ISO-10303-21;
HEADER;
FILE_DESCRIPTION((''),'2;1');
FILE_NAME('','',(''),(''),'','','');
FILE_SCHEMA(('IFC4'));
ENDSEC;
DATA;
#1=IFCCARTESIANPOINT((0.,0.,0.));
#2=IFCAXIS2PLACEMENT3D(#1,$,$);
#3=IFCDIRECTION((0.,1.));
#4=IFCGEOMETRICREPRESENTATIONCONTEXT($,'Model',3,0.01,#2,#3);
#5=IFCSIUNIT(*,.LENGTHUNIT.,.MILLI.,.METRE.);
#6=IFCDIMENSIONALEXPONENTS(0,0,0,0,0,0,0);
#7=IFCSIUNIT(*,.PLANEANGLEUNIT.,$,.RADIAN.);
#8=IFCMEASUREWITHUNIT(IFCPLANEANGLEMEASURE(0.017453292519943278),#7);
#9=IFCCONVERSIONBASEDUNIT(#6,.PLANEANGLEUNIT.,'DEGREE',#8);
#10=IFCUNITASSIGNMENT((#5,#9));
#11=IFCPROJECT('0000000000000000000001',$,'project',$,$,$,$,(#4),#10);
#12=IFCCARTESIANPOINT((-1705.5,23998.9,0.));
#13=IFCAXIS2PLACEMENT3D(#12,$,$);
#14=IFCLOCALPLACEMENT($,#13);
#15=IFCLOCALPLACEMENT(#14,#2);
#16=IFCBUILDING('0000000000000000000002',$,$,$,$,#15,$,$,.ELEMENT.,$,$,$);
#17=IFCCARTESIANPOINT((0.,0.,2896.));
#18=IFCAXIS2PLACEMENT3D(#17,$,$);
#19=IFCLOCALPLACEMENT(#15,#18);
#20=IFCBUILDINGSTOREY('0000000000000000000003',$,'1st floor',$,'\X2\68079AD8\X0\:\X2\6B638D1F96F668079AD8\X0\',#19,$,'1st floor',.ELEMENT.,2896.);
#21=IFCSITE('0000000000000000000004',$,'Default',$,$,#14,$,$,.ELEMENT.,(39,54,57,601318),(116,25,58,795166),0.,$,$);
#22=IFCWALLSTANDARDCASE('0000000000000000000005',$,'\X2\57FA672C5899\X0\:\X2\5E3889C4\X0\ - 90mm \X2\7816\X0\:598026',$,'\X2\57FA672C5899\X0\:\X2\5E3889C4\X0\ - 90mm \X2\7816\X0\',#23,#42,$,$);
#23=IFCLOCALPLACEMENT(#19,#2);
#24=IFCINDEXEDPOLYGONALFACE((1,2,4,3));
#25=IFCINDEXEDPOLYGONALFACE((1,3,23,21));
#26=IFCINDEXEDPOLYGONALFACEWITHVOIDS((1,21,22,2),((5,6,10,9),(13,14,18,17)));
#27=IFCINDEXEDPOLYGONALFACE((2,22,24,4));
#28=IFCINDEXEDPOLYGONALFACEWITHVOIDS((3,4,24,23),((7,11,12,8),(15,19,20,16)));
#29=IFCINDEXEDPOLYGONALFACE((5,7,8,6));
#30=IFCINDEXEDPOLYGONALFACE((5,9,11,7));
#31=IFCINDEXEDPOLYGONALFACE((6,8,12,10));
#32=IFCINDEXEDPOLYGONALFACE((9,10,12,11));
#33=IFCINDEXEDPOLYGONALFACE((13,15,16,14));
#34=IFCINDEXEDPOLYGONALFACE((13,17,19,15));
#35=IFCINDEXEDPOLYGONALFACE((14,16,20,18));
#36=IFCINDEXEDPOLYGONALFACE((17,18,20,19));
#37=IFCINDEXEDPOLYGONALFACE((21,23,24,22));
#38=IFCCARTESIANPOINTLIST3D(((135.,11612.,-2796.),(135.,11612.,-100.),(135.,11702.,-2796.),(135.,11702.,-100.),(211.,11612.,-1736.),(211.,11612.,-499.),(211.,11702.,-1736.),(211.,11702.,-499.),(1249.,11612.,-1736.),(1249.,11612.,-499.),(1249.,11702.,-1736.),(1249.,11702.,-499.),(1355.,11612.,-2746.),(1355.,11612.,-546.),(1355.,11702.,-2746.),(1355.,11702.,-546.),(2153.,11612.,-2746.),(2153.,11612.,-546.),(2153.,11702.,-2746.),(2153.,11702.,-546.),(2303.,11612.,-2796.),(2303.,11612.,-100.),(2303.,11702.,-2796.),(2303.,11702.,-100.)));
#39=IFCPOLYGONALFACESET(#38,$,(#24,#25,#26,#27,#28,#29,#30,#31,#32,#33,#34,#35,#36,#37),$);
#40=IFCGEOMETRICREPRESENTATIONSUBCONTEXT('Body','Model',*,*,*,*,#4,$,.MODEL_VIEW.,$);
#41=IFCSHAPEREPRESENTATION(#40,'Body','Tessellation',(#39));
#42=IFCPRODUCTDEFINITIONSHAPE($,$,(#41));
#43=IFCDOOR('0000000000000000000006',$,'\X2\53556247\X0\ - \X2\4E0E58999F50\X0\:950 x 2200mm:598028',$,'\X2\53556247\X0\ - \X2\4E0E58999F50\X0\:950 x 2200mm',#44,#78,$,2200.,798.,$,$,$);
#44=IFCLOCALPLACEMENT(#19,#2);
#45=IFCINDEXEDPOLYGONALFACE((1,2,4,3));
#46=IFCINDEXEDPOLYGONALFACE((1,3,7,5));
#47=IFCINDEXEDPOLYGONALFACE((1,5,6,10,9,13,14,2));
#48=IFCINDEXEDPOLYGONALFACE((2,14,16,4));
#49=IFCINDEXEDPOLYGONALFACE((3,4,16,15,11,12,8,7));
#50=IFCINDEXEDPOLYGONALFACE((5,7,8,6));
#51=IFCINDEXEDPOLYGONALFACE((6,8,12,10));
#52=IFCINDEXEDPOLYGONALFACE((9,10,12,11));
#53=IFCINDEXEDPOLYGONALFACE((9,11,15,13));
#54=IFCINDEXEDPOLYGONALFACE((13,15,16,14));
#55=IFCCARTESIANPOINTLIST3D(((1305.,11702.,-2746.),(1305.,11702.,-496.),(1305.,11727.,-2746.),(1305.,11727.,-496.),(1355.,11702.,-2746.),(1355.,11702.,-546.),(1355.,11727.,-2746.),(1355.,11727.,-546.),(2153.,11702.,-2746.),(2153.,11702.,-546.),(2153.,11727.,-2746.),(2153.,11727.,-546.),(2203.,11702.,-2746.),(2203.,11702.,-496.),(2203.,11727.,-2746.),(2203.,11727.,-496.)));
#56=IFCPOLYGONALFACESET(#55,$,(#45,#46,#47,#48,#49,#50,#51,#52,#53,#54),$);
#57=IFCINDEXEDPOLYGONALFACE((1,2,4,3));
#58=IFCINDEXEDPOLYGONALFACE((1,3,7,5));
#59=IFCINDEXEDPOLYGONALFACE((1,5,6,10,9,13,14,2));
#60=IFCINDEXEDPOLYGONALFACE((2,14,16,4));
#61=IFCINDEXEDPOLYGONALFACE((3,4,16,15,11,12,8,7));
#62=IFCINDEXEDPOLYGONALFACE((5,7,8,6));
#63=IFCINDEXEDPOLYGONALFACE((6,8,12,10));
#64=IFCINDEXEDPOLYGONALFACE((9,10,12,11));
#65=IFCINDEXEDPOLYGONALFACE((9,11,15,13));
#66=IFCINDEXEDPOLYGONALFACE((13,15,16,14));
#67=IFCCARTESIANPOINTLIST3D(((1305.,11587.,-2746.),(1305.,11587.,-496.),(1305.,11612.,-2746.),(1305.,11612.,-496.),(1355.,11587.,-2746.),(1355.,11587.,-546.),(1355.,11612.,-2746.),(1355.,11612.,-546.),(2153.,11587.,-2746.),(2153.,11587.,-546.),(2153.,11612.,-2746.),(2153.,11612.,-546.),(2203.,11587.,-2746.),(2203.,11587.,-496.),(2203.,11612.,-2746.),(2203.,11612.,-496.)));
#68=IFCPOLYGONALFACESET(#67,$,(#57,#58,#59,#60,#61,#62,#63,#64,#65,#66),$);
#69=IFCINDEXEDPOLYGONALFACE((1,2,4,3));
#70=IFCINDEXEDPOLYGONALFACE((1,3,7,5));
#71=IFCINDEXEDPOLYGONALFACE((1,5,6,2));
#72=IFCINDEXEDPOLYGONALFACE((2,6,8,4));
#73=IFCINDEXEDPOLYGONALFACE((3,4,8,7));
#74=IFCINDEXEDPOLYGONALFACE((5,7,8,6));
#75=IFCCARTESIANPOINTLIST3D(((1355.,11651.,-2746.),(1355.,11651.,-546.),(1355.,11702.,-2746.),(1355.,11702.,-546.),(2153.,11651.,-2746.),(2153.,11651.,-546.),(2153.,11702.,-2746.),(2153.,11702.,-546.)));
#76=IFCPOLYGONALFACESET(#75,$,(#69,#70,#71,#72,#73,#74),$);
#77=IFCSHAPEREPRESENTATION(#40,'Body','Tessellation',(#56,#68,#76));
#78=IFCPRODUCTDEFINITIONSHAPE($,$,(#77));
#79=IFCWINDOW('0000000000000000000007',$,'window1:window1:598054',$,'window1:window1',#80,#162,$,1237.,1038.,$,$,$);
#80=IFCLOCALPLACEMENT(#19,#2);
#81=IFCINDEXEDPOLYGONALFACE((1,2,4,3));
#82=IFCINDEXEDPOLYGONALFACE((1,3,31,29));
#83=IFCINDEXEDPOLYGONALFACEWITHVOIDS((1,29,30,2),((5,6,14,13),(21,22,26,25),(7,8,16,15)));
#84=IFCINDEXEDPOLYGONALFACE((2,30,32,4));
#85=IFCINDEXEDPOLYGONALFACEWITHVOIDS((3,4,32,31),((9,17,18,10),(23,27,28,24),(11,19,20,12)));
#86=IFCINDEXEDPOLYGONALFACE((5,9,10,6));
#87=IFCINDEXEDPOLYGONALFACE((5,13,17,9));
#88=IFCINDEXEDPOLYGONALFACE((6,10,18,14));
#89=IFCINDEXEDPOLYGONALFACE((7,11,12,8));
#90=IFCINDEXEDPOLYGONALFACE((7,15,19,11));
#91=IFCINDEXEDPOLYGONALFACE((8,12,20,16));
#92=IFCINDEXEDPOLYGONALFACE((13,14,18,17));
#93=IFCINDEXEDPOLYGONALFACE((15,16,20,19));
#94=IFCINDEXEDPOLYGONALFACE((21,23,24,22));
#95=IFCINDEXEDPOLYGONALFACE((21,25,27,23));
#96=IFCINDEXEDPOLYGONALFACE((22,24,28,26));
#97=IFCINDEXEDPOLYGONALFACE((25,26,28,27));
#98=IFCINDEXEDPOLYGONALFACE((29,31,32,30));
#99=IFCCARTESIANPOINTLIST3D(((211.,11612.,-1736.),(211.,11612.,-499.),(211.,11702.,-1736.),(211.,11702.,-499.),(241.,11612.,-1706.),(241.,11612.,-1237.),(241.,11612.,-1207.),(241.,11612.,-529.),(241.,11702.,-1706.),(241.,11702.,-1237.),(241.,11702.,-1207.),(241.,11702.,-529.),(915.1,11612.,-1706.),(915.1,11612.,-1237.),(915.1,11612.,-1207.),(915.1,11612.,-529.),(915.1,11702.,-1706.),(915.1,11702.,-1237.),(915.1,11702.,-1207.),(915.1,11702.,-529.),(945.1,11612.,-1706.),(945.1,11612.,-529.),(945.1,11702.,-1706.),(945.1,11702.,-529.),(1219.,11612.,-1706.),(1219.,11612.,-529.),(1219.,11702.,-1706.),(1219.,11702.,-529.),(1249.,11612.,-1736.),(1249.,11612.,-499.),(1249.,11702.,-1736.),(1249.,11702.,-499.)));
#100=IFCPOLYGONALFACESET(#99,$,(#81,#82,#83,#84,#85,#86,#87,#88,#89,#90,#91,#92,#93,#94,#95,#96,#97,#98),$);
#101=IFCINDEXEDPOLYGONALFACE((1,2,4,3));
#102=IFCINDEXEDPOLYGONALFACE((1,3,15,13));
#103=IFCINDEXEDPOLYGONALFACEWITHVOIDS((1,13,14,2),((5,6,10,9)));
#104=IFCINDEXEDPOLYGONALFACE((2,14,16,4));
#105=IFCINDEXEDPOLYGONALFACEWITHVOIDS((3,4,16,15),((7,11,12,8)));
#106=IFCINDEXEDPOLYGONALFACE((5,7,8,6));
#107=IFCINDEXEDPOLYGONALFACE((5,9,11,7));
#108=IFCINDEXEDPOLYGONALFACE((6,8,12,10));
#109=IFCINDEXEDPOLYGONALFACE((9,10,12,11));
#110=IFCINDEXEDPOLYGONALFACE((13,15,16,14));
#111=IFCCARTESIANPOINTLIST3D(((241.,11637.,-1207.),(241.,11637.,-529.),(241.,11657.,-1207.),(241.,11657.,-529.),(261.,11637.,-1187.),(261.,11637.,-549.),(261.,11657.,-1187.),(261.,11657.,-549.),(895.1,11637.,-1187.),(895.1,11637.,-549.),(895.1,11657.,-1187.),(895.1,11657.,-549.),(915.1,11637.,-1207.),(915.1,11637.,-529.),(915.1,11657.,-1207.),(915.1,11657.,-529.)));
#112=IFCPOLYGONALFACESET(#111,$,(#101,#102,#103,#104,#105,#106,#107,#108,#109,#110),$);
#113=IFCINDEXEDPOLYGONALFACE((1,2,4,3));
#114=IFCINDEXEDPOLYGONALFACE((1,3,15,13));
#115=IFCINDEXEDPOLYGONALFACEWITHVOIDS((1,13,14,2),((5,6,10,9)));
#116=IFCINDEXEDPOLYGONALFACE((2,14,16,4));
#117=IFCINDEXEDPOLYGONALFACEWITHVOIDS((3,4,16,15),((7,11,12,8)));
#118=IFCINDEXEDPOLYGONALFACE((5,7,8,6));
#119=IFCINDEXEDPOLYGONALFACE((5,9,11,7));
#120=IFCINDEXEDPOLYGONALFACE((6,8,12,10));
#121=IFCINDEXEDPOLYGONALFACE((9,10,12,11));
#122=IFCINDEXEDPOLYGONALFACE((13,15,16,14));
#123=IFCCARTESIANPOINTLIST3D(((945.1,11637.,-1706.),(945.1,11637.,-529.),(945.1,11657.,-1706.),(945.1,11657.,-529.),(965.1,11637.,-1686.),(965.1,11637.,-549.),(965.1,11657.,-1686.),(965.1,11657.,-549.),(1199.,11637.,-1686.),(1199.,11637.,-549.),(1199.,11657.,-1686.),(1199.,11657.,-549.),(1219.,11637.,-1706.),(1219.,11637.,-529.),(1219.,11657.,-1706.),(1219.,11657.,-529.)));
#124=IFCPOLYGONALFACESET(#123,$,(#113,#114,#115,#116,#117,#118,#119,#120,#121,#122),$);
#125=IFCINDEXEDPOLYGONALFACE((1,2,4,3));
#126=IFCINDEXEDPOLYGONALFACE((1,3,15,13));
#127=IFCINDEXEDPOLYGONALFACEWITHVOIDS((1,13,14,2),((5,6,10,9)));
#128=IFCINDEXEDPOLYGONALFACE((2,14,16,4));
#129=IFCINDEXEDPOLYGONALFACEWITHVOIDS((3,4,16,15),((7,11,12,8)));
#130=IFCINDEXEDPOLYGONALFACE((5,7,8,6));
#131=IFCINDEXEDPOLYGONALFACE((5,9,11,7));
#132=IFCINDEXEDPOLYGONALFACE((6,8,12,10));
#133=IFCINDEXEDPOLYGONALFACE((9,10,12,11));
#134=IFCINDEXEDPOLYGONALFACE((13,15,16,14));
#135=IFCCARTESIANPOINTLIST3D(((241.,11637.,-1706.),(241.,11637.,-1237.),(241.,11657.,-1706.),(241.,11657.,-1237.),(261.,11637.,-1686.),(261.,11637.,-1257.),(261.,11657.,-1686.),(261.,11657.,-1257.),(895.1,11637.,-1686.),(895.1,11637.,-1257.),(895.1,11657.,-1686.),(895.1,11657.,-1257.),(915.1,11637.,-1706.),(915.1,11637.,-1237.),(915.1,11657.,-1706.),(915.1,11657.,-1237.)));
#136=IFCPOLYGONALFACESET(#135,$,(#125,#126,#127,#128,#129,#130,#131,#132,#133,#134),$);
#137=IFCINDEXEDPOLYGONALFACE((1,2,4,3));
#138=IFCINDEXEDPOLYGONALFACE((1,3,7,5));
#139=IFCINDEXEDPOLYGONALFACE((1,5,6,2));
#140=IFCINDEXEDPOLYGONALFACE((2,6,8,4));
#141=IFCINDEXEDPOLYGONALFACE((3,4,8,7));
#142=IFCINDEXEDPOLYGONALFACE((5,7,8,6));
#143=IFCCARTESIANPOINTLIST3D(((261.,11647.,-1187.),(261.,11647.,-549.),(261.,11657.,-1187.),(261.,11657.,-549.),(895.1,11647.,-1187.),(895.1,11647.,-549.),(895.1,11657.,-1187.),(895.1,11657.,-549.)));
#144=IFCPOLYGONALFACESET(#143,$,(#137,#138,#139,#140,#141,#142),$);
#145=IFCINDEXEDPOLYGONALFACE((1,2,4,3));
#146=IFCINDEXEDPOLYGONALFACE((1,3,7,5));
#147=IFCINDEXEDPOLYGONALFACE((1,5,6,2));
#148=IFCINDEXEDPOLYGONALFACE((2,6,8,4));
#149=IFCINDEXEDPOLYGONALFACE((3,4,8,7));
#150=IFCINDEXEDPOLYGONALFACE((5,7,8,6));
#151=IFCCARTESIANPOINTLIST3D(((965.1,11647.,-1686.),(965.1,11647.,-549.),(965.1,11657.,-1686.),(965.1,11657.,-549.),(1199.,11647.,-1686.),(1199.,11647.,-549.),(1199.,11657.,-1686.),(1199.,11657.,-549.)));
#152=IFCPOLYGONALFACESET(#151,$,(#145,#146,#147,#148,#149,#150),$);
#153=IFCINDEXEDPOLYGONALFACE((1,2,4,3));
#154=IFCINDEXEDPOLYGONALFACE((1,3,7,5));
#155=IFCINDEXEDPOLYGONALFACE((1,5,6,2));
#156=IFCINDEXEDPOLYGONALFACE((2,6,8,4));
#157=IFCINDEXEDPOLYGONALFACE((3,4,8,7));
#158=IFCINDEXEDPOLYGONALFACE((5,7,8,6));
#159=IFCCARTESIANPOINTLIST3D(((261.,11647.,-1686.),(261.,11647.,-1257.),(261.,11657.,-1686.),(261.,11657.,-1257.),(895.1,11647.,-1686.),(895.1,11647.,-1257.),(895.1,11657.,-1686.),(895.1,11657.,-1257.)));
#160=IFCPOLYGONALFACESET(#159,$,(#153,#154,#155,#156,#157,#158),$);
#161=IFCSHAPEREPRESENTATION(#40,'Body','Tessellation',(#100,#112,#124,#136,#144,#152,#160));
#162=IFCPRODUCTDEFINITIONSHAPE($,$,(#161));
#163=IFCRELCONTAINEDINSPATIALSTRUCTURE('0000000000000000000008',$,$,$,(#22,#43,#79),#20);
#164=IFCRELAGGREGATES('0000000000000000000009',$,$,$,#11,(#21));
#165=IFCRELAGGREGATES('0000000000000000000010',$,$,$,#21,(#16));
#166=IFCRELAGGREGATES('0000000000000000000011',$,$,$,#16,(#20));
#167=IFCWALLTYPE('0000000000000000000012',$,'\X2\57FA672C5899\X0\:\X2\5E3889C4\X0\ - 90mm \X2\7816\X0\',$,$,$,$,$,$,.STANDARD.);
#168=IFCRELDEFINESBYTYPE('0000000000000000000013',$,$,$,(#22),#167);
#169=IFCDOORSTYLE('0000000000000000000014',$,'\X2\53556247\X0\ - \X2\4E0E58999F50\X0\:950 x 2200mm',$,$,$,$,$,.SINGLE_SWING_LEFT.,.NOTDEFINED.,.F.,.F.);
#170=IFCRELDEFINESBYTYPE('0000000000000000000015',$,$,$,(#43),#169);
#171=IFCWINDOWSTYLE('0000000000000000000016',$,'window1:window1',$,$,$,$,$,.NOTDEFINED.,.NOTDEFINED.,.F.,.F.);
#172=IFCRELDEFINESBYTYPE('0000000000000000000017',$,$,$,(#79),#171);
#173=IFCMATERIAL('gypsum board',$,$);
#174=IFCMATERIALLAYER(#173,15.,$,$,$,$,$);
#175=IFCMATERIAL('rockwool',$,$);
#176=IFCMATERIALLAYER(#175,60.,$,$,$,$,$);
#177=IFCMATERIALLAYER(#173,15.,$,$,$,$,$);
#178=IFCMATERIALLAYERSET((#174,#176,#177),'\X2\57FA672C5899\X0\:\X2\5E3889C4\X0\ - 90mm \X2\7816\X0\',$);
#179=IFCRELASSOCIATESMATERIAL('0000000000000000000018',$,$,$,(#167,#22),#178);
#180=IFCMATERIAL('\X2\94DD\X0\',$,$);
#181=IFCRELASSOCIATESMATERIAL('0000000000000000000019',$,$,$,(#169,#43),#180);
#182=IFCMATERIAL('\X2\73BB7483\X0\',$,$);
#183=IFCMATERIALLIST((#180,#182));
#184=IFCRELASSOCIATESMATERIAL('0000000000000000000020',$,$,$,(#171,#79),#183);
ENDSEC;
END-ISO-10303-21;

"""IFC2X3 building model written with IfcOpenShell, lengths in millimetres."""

from ifc_helpers import new_model, entity, si_unit, converted_unit, direction, frame, frame_2d, origin, origin_2d_with_axis, place, context, subcontext, project, spatial, polyline, rectangle, outline, extrude, source, transform, mapped, material, material_list, layer, layer_set, layer_usage, type_object, type_shapes, element, fill, save


model = new_model("IFC2X3")

# Units and contexts
model_context = context("Model", 3, precision=0.01, world=origin(), true_north=direction((0.0, 1.0)))
body_context = subcontext(model_context, "Body", "Model", "MODEL_VIEW")
ifc_project = project(units=[si_unit("LENGTHUNIT", "METRE", prefix="MILLI"), converted_unit("PLANEANGLEUNIT", "DEGREE", entity("IfcPlaneAngleMeasure", 0.017453292519943278), si_unit("PLANEANGLEUNIT", "RADIAN"), dimensions=[0, 0, 0, 0, 0, 0, 0])], contexts=[model_context])

# Site, building, storey
site_placement = place(None, frame((-1705.5, 23998.9, 0.0)))
site = spatial("IfcSite", under=ifc_project, at=site_placement, Name="Default", CompositionType="ELEMENT", RefLatitude=(39, 54, 57, 601318), RefLongitude=(116, 25, 58, 795166), RefElevation=0.0)
building_placement = place(site_placement, origin())
building = spatial("IfcBuilding", under=site, at=building_placement, CompositionType="ELEMENT")
storey_placement = place(building_placement, frame((0.0, 0.0, 2896.0)))
storey = spatial("IfcBuildingStorey", under=building, at=storey_placement, Name="1st floor", ObjectType="标高:正负零标高", LongName="1st floor", CompositionType="ELEMENT", Elevation=2896.0)

# Shared definitions
ifc_material_1 = material(Name="gypsum board")
ifc_layer_1 = layer(ifc_material_1, 15.0)
ifc_material_2 = material(Name="rockwool")
ifc_layer_2 = layer(ifc_material_2, 60.0)
ifc_layer_3 = layer(ifc_material_1, 15.0)
ifc_layer_set = layer_set([ifc_layer_1, ifc_layer_2, ifc_layer_3], Name="基本墙:常规 - 90mm 砖")
wall_type = type_object("IfcWallType", Name="基本墙:常规 - 90mm 砖", PredefinedType="STANDARD", material=ifc_layer_set)

# Wall, openings, door, window
ifc_layer_usage_1 = layer_usage(ifc_layer_set, "AXIS2", "NEGATIVE", 45.0)
wall_1_placement = place(storey_placement, frame((2303.0, 11657.0, -2796.0), z_axis=(0.0, 0.0, 1.0), x_axis=(-1.0, 0.0, 0.0)))
wall_1 = element("IfcWallStandardCase", 1, at=wall_1_placement, inside=storey, type_object=wall_type, material=ifc_layer_usage_1, Name="基本墙:常规 - 90mm 砖:598026", ObjectType="基本墙:常规 - 90mm 砖", context=body_context, shape_type="SweptSolid", body=[
    extrude(rectangle(XDim=2168.0, YDim=90.0, at=frame_2d((1084.0, 0.0), x_axis=(-1.0, 0.0))), origin(), (0.0, 0.0, 1.0), 2696.0),
])
opening_1_placement = place(wall_1_placement, frame((948.0, 45.0, 50.0)))
opening_1 = element("IfcOpeningElement", 2, at=opening_1_placement, cuts=wall_1, ObjectType="Opening", context=body_context, shape_type="SweptSolid", body=[
    extrude(rectangle(XDim=798.0, YDim=2200.0, at=frame_2d((1100.0, 399.0), x_axis=(0.0, -1.0))), frame((0.0, 0.0, 0.0), z_axis=(0.0, -1.0, 0.0), x_axis=(0.0, 0.0, 1.0)), (0.0, 0.0, 1.0), 90.0),
])
opening_2_placement = place(wall_1_placement, frame((2092.0, 45.0, 1060.0)))
opening_2 = element("IfcOpeningElement", 3, at=opening_2_placement, cuts=wall_1, ObjectType="Opening", context=body_context, shape_type="SweptSolid", body=[
    extrude(rectangle(XDim=1237.0, YDim=1038.0, at=frame_2d((618.5, 519.0), x_axis=(1.0, 0.0))), frame((0.0, 0.0, 0.0), z_axis=(0.0, -1.0, 0.0), x_axis=(0.0, 0.0, 1.0)), (0.0, 0.0, 1.0), 90.0),
])
ifc_material_3 = material(Name="铝")
door_style = type_object("IfcDoorStyle", Name="单扇 - 与墙齐:950 x 2200mm", ConstructionType="NOTDEFINED", OperationType="SINGLE_SWING_LEFT", ParameterTakesPrecedence=False, Sizeable=False, material=ifc_material_3)
shared_shape_1 = source(origin(), body_context, "Body", "SweptSolid", [
    extrude(outline(polyline([(-449.0, -1137.5), (449.0, -1137.5), (449.0, 1112.5), (399.0, 1112.5), (399.0, -1087.5), (-399.0, -1087.5), (-399.0, 1112.5), (-449.0, 1112.5), (-449.0, -1137.5)])), frame((399.0, 115.0, 1112.5), z_axis=(0.0, -1.0, 0.0), x_axis=(-1.0, 0.0, 0.0)), (0.0, 0.0, 1.0), 25.0),
    extrude(outline(polyline([(-1137.5, -449.0), (1112.5, -449.0), (1112.5, -399.0), (-1087.5, -399.0), (-1087.5, 399.0), (1112.5, 399.0), (1112.5, 449.0), (-1137.5, 449.0), (-1137.5, -449.0)])), frame((399.0, 0.0, 1112.5), z_axis=(0.0, -1.0, 0.0), x_axis=(0.0, 0.0, -1.0)), (0.0, 0.0, 1.0), 25.0),
    extrude(rectangle(XDim=798.0, YDim=51.0, at=origin_2d_with_axis()), frame((399.0, 64.5, 0.0)), (0.0, 0.0, 1.0), 2200.0),
])
type_shapes(door_style, [shared_shape_1])
door_placement = place(opening_1_placement, frame((0.0, 0.0, 0.0), z_axis=(0.0, 0.0, 1.0), x_axis=(-1.0, 0.0, 0.0)))
door = element("IfcDoor", 4, at=door_placement, inside=storey, type_object=door_style, material=ifc_material_3, Name="单扇 - 与墙齐:950 x 2200mm:598028", ObjectType="单扇 - 与墙齐:950 x 2200mm", OverallHeight=2200.0, OverallWidth=798.0, context=body_context, shape_type="MappedRepresentation", body=[
    mapped(shared_shape_1, transform((0.0, 0.0, 0.0), scale=1.0)),
])
fill(opening_1, door)
ifc_material_4 = material(Name="玻璃")
ifc_material_list = material_list([ifc_material_3, ifc_material_4])
window_style = type_object("IfcWindowStyle", Name="window1:window1", ConstructionType="NOTDEFINED", OperationType="NOTDEFINED", ParameterTakesPrecedence=False, Sizeable=False, material=ifc_material_list)
shared_shape_2 = source(origin(), body_context, "Body", "SweptSolid", [
    extrude(outline(polyline([(-618.5, -519.0), (618.5, -519.0), (618.5, 519.0), (-618.5, 519.0), (-618.5, -519.0)]), holes=[polyline([(-588.5, -215.1), (588.5, -215.1), (588.5, -489.0), (-588.5, -489.0), (-588.5, -215.1)]), polyline([(89.5, -185.1), (-588.5, -185.1), (-588.5, 489.0), (89.5, 489.0), (89.5, -185.1)]), polyline([(119.5, 489.0), (588.5, 489.0), (588.5, -185.1), (119.5, -185.1), (119.5, 489.0)])]), frame((519.0, 0.0, 618.5), z_axis=(0.0, 1.0, 0.0), x_axis=(0.0, 0.0, -1.0)), (0.0, 0.0, 1.0), 90.0),
    extrude(outline(polyline([(-337.0, -339.0), (337.0, -339.0), (337.0, 339.0), (-337.0, 339.0), (-337.0, -339.0)]), holes=[polyline([(-317.0, -319.0), (-317.0, 319.0), (317.0, 319.0), (317.0, -319.0), (-317.0, -319.0)])]), frame((367.0, 25.0, 868.0), z_axis=(0.0, 1.0, 0.0), x_axis=(1.0, 0.0, 0.0)), (0.0, 0.0, 1.0), 20.0),
    extrude(outline(polyline([(-137.0, -588.5), (137.0, -588.5), (137.0, 588.5), (-137.0, 588.5), (-137.0, -588.5)]), holes=[polyline([(-117.0, -568.5), (-117.0, 568.5), (117.0, 568.5), (117.0, -568.5), (-117.0, -568.5)])]), frame((871.0, 25.0, 618.5), z_axis=(0.0, 1.0, 0.0), x_axis=(1.0, 0.0, 0.0)), (0.0, 0.0, 1.0), 20.0),
    extrude(outline(polyline([(-337.0, -234.5), (337.0, -234.5), (337.0, 234.5), (-337.0, 234.5), (-337.0, -234.5)]), holes=[polyline([(-317.0, -214.5), (-317.0, 214.5), (317.0, 214.5), (317.0, -214.5), (-317.0, -214.5)])]), frame((367.0, 25.0, 264.5), z_axis=(0.0, 1.0, 0.0), x_axis=(1.0, 0.0, 0.0)), (0.0, 0.0, 1.0), 20.0),
    extrude(rectangle(XDim=10.0, YDim=634.1, at=frame_2d((0.0, 0.0), x_axis=(1.0, 0.0))), frame((367.0, 40.0, 549.0), z_axis=(0.0, 0.0, 1.0), x_axis=(0.0, 1.0, 0.0)), (0.0, 0.0, 1.0), 638.0),
    extrude(rectangle(XDim=10.0, YDim=233.9, at=frame_2d((0.0, 0.0), x_axis=(1.0, 0.0))), frame((871.0, 40.0, 50.0), z_axis=(0.0, 0.0, 1.0), x_axis=(0.0, 1.0, 0.0)), (0.0, 0.0, 1.0), 1137.0),
    extrude(rectangle(XDim=10.0, YDim=634.1, at=origin_2d_with_axis()), frame((367.0, 40.0, 50.0), z_axis=(0.0, 0.0, 1.0), x_axis=(0.0, 1.0, 0.0)), (0.0, 0.0, 1.0), 429.0),
])
type_shapes(window_style, [shared_shape_2])
window_placement = place(opening_2_placement, frame((0.0, 0.0, 0.0), z_axis=(0.0, 0.0, 1.0), x_axis=(-1.0, 0.0, 0.0)))
window = element("IfcWindow", 5, at=window_placement, inside=storey, type_object=window_style, material=ifc_material_list, Name="window1:window1:598054", ObjectType="window1:window1", OverallHeight=1237.0, OverallWidth=1038.0, context=body_context, shape_type="MappedRepresentation", body=[
    mapped(shared_shape_2, transform((0.0, 0.0, 0.0), scale=1.0)),
])
fill(opening_2, window)

save(model, "model.ifc")
